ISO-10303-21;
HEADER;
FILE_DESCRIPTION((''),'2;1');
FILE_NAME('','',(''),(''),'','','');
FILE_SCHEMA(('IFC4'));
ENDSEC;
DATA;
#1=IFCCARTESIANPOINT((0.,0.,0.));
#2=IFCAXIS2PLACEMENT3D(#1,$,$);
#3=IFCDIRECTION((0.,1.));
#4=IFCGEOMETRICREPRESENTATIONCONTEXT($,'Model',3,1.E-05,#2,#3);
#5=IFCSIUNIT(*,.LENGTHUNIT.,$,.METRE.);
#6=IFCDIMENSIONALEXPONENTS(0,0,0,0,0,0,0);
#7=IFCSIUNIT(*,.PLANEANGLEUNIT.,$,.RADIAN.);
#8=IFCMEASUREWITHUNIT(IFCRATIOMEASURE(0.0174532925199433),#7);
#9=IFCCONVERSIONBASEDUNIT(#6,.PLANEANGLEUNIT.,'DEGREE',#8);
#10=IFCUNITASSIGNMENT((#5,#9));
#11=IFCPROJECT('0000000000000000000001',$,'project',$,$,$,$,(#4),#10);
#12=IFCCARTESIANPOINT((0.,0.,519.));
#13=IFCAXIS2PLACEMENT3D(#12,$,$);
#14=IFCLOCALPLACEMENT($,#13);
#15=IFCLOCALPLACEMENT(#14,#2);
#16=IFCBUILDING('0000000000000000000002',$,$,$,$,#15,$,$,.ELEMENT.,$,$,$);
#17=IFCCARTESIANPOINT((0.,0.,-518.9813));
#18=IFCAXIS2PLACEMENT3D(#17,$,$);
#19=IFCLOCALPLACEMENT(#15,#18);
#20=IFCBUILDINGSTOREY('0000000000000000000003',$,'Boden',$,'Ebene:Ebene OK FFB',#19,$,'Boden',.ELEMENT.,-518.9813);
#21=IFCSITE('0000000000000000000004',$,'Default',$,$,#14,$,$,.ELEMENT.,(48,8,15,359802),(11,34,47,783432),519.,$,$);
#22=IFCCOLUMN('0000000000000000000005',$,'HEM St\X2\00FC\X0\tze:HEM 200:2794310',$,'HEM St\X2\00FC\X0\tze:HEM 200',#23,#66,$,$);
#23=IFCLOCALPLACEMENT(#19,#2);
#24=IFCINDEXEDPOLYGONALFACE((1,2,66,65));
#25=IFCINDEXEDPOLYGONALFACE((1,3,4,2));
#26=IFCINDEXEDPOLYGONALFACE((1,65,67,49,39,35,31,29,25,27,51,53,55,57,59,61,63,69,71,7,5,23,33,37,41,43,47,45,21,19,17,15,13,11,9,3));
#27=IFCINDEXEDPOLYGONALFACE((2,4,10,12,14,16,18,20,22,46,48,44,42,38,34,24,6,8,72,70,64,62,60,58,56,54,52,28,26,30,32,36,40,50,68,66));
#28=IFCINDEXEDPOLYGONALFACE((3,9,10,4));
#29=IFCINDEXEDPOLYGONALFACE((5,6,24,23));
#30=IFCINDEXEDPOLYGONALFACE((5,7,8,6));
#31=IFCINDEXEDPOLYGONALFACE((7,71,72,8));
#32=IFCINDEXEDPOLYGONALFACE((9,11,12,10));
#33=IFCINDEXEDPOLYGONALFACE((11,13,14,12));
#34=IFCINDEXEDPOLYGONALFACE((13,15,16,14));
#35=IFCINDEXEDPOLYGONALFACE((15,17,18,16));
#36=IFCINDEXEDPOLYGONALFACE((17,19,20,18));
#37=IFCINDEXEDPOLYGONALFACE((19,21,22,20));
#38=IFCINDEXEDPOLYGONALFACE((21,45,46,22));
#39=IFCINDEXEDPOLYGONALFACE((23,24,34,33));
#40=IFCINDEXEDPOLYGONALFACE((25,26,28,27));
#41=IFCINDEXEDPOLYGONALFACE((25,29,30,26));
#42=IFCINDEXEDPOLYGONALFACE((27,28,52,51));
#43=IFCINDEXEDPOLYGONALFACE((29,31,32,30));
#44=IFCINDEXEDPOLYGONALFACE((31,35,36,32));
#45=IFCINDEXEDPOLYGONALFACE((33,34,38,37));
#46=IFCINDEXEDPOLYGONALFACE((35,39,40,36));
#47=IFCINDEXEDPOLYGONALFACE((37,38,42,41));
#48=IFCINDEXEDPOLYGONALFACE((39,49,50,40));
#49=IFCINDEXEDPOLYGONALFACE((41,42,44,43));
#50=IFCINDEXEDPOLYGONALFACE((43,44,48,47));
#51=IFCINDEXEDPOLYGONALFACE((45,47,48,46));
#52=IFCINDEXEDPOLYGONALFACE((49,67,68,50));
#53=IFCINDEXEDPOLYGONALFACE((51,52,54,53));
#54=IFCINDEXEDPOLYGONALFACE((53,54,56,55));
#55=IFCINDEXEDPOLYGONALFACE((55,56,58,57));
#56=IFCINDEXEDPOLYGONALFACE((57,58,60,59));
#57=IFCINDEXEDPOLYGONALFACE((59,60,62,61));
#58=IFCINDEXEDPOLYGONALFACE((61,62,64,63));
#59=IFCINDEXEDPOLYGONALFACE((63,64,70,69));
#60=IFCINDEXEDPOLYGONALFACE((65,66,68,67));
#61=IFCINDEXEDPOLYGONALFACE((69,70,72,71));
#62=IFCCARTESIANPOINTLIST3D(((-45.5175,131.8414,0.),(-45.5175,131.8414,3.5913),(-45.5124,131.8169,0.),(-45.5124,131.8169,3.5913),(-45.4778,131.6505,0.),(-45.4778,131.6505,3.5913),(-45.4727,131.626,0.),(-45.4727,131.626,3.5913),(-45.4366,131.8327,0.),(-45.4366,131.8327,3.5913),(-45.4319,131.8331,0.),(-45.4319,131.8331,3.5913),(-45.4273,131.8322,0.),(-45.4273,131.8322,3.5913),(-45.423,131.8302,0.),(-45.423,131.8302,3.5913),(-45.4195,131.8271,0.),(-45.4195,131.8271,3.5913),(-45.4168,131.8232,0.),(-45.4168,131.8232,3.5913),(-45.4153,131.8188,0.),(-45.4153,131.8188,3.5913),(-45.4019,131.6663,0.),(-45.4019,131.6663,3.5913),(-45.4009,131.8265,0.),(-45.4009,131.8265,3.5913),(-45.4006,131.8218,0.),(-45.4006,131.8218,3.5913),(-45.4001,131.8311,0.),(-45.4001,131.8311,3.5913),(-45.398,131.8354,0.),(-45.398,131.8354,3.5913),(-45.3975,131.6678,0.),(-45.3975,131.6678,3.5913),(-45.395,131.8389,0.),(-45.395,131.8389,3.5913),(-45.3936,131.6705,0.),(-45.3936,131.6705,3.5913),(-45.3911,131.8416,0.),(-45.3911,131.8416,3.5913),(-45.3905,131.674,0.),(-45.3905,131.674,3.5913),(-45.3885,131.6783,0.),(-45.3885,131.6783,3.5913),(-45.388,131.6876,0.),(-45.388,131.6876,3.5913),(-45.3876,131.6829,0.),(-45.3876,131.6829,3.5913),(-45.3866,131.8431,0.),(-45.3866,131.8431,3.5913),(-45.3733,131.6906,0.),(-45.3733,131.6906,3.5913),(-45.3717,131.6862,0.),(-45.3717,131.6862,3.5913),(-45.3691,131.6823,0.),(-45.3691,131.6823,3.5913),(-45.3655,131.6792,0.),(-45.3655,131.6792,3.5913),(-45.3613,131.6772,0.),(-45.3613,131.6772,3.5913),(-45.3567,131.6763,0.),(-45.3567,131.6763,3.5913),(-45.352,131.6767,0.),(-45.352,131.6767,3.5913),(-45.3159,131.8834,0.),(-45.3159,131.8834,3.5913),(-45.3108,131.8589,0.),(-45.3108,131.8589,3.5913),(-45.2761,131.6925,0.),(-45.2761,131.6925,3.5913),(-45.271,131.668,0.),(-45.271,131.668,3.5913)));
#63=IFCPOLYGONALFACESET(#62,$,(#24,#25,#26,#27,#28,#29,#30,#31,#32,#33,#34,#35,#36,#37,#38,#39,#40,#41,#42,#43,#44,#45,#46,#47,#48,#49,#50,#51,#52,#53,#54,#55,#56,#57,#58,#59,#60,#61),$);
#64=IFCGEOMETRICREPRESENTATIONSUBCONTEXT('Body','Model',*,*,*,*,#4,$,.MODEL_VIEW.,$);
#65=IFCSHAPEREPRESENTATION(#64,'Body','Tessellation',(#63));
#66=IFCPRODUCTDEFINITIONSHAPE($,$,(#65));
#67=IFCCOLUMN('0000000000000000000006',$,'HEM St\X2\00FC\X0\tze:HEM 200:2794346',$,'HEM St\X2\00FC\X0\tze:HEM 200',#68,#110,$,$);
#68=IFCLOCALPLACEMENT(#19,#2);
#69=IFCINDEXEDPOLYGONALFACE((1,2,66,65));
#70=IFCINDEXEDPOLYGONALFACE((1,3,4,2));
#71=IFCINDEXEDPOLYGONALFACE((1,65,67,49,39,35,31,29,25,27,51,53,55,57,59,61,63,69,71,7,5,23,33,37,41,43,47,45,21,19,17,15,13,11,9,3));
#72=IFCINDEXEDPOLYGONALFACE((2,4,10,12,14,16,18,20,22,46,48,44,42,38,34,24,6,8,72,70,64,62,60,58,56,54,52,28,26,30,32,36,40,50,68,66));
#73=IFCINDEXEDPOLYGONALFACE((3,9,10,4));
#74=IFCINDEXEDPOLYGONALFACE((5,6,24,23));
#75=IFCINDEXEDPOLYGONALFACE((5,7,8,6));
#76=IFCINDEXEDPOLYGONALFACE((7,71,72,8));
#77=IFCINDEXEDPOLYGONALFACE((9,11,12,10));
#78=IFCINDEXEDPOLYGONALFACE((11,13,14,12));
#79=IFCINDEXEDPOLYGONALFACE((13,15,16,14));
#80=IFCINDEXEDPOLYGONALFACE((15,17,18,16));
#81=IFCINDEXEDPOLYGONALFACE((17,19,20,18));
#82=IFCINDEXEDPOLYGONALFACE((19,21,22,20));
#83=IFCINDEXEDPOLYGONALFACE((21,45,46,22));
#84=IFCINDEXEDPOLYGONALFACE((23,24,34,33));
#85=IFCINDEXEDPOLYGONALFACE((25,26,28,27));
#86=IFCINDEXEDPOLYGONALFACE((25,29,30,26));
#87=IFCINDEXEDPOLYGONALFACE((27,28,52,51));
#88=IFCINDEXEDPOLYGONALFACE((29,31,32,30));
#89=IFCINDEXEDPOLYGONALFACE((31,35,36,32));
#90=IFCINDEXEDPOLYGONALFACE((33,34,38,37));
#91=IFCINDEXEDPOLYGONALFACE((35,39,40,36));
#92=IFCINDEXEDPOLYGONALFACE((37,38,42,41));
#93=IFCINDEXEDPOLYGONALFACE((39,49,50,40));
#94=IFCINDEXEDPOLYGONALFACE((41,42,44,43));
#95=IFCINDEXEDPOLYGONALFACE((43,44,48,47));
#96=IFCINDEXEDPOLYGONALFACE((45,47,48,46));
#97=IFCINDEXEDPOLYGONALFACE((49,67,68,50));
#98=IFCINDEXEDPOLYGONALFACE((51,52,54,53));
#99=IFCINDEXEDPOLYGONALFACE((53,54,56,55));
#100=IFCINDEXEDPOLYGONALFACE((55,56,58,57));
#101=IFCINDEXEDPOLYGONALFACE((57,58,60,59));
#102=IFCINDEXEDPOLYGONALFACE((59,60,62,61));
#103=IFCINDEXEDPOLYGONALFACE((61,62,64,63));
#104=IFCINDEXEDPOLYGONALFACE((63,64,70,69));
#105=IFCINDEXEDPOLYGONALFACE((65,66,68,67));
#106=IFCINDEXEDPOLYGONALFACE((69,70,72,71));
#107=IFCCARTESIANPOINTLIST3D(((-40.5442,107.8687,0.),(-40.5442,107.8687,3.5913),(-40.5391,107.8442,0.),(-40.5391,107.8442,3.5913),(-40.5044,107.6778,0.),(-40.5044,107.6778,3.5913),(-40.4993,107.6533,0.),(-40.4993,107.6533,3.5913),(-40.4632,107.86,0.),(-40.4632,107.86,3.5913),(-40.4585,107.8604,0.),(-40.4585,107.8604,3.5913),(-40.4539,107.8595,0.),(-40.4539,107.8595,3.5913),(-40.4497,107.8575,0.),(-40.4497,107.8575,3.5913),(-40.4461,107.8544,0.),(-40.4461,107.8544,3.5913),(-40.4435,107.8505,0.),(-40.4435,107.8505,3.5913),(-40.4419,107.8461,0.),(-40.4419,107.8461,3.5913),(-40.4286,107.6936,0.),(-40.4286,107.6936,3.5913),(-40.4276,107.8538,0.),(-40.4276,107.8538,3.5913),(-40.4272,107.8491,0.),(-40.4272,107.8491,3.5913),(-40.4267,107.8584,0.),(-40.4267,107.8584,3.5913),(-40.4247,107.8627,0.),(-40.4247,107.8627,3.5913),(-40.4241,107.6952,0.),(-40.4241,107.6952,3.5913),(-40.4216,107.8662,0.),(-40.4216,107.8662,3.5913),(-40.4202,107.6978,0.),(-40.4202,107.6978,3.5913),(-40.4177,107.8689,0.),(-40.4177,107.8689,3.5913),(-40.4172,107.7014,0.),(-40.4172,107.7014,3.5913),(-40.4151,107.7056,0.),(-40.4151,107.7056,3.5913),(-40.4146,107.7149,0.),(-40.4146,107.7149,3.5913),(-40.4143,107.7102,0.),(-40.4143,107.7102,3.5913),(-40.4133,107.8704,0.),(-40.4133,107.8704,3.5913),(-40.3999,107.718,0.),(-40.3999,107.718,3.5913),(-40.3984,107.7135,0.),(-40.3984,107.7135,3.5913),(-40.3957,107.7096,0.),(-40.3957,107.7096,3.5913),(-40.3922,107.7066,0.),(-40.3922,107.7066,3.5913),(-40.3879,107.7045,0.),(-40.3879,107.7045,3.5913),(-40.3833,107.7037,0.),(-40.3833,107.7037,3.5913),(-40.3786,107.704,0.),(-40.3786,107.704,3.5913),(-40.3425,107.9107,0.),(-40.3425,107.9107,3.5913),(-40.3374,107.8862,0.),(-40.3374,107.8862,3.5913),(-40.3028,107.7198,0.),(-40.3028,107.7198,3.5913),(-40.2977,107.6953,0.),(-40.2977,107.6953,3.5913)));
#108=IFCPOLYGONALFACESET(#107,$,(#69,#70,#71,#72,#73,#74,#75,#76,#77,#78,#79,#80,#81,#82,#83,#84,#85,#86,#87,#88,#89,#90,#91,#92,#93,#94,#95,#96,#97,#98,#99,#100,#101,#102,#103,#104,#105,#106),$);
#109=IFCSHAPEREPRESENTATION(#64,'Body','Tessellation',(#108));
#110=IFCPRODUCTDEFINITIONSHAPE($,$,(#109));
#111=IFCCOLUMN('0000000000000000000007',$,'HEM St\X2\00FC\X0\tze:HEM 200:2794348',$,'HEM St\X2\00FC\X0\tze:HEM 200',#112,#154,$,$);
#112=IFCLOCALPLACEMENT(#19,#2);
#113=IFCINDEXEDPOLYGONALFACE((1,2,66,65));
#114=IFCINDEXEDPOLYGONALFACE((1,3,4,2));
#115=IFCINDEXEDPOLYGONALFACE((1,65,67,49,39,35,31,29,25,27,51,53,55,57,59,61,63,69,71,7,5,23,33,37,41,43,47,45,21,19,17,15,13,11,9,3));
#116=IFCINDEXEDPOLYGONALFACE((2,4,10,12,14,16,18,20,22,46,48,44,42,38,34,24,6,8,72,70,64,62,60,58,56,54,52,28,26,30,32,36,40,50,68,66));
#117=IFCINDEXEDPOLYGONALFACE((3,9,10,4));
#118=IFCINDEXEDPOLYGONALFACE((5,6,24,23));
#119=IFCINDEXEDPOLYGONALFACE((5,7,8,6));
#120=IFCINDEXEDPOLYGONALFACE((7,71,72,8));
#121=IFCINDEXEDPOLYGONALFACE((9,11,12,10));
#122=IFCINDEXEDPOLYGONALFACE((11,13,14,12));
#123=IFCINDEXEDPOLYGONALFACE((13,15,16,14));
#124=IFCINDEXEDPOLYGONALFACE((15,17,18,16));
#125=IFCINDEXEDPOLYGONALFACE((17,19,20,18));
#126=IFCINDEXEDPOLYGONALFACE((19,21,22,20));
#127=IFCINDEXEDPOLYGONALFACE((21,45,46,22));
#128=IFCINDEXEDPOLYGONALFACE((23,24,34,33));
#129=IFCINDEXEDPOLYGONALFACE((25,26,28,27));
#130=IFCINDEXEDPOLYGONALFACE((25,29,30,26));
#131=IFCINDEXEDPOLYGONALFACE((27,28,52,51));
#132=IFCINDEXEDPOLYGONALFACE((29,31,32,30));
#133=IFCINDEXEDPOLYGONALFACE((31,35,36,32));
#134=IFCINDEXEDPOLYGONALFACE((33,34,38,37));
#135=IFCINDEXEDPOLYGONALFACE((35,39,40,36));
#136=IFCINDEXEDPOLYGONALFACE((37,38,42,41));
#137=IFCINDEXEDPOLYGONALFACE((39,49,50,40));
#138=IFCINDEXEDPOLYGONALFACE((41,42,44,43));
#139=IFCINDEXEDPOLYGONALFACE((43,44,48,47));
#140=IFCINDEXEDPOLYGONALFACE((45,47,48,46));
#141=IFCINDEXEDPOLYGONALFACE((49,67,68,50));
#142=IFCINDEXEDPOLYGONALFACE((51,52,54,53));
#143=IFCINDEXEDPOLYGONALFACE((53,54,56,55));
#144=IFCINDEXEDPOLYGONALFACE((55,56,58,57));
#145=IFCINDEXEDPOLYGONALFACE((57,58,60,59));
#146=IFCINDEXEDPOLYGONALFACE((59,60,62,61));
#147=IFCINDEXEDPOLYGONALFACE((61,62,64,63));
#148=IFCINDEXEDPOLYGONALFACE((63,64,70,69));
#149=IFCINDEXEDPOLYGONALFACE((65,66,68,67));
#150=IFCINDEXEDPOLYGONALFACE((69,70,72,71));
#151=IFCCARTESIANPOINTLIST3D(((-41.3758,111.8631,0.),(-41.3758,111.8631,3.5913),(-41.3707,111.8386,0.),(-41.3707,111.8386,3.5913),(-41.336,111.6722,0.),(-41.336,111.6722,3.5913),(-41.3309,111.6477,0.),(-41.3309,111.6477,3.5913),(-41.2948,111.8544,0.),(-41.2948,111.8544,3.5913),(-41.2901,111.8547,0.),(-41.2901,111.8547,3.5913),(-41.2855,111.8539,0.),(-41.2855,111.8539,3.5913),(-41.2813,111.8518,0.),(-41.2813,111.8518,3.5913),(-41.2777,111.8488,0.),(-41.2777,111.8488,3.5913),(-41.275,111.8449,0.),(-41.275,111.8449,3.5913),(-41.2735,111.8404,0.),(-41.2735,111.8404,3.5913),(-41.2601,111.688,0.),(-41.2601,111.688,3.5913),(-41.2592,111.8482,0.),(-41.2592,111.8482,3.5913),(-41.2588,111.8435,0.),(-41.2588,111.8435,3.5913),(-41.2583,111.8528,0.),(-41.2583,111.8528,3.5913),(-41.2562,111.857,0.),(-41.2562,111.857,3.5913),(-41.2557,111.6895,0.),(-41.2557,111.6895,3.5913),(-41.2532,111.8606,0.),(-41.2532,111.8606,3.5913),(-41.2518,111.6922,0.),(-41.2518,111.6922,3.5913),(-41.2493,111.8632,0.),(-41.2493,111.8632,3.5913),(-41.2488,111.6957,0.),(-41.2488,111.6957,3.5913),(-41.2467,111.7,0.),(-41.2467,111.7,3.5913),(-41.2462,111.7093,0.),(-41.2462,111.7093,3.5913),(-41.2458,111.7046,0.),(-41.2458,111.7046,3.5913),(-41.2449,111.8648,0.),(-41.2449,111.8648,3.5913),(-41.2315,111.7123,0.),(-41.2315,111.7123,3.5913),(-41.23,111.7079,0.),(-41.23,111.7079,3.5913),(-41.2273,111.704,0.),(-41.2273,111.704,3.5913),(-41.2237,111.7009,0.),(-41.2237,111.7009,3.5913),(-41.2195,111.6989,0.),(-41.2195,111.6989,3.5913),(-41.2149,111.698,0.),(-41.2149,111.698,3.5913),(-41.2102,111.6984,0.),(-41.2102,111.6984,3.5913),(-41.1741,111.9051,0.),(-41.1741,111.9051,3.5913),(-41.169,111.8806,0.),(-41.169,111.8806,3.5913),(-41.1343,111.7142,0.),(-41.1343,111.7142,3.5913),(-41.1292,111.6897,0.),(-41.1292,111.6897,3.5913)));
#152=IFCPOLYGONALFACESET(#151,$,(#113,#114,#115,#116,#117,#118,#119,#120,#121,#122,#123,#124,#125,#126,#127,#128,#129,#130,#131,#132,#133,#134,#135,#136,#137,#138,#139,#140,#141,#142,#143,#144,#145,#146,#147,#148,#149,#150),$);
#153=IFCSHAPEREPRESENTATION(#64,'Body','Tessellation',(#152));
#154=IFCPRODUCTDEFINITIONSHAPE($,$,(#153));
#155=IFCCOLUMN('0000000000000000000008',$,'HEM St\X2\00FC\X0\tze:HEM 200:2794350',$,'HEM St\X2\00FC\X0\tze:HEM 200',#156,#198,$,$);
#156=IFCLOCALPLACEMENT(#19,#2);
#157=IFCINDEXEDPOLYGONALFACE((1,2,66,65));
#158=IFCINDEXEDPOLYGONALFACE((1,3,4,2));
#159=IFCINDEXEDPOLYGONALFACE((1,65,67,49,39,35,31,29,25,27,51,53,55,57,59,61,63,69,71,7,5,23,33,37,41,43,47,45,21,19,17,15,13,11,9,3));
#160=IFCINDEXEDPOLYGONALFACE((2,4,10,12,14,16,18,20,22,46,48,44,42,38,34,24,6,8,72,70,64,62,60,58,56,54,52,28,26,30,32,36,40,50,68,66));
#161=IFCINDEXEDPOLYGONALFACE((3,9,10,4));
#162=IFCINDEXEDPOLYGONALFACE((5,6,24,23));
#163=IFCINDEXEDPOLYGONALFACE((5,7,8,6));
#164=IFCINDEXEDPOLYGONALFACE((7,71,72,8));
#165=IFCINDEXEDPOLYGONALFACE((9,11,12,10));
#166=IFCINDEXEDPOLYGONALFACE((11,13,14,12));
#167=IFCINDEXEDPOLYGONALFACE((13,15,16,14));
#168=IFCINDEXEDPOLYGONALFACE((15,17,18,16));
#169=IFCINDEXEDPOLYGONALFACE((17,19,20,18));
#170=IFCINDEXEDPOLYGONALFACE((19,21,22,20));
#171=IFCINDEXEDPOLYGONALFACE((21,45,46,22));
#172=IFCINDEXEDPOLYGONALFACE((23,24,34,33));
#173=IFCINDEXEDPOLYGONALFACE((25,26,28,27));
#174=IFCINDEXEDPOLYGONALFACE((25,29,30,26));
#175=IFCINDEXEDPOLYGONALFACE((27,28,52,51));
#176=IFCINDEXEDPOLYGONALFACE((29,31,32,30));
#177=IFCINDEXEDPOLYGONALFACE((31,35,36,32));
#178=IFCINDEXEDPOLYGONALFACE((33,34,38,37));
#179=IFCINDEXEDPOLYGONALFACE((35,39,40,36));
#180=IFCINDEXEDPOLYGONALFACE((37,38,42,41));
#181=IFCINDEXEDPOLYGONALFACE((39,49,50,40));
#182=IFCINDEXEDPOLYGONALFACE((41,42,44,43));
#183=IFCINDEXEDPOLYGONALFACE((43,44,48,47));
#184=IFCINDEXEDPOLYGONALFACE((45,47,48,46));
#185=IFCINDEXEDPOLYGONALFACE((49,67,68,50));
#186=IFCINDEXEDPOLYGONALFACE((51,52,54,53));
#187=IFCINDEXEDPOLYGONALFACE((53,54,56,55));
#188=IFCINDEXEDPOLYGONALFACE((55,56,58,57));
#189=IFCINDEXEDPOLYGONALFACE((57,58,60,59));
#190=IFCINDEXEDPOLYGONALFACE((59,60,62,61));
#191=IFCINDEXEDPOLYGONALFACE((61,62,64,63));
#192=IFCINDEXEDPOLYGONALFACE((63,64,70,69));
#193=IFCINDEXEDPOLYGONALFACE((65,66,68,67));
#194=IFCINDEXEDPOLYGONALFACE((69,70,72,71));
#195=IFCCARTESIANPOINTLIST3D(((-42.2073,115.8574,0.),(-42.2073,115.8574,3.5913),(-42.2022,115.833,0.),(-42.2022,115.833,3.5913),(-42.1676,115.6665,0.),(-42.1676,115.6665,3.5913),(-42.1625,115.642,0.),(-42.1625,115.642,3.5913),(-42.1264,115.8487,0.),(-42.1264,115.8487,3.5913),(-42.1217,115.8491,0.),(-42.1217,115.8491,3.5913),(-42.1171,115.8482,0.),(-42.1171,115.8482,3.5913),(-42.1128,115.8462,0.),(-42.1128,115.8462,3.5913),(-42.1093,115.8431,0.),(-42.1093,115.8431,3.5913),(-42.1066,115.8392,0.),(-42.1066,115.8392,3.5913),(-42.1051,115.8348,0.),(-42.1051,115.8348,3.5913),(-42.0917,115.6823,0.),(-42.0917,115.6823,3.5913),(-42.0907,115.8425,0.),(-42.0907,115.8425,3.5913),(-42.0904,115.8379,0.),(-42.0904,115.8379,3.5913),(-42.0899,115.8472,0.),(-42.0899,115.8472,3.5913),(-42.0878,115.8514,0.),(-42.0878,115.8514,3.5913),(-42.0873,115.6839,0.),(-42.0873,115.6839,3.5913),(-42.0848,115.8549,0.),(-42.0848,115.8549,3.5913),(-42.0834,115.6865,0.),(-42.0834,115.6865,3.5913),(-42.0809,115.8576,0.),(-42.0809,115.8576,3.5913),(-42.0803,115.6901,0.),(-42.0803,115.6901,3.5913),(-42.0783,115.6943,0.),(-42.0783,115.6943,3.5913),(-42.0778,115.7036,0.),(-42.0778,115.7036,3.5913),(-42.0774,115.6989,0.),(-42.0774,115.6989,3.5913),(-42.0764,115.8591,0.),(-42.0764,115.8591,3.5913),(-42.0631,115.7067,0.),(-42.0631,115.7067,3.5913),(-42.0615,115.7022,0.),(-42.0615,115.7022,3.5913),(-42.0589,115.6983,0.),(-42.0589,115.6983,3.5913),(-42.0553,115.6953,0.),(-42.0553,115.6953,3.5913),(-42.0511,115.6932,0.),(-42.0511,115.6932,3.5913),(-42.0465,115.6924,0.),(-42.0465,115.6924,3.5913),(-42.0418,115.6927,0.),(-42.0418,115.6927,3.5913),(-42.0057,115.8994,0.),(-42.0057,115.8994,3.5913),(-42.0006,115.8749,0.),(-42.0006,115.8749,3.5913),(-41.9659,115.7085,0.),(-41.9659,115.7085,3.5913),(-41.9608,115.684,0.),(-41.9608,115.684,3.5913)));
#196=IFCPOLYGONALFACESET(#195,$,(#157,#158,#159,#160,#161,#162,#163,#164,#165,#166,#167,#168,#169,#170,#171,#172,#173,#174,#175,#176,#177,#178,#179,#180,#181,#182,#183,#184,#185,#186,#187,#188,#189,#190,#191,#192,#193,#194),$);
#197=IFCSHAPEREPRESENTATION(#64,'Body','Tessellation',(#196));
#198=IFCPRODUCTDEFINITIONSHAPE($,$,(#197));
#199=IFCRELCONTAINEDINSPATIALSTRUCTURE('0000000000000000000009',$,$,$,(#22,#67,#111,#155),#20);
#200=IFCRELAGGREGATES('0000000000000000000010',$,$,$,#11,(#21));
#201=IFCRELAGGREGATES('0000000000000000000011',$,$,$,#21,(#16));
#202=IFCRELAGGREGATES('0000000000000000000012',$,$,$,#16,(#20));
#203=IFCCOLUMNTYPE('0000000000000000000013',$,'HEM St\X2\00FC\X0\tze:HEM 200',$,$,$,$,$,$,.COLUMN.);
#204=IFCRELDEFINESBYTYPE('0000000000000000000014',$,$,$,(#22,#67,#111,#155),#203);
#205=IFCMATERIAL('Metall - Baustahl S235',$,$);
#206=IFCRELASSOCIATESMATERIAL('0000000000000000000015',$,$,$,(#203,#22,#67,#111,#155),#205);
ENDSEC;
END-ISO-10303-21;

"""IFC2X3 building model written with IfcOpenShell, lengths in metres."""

from ifc_helpers import new_model, entity, si_unit, converted_unit, direction, frame, frame_2d, origin, place, context, subcontext, project, spatial, polyline, circle_curve, parameter, trimmed, segment, composite_curve, outline, extrude, source, transform, mapped, material, type_object, type_shapes, element, save


model = new_model("IFC2X3")

# Units and contexts
model_context = context("Model", 3, precision=1e-05, world=origin(), true_north=direction((0.0, 1.0)))
body_context = subcontext(model_context, "Body", "Model", "MODEL_VIEW")
ifc_project = project(units=[si_unit("LENGTHUNIT", "METRE"), converted_unit("PLANEANGLEUNIT", "DEGREE", entity("IfcRatioMeasure", 0.0174532925199433), si_unit("PLANEANGLEUNIT", "RADIAN"), dimensions=[0, 0, 0, 0, 0, 0, 0])], contexts=[model_context])

# Site, building, storey
site_placement = place(None, frame((0.0, 0.0, 519.0)))
site = spatial("IfcSite", under=ifc_project, at=site_placement, Name="Default", CompositionType="ELEMENT", RefLatitude=(48, 8, 15, 359802), RefLongitude=(11, 34, 47, 783432), RefElevation=519.0)
building_placement = place(site_placement, origin())
building = spatial("IfcBuilding", under=site, at=building_placement, CompositionType="ELEMENT")
storey_placement = place(building_placement, frame((0.0, 0.0, -518.9813)))
storey = spatial("IfcBuildingStorey", under=building, at=storey_placement, Name="Boden", ObjectType="Ebene:Ebene OK FFB", LongName="Boden", CompositionType="ELEMENT", Elevation=-518.9813)

# Columns
ifc_material = material(Name="Metall - Baustahl S235")
column_type = type_object("IfcColumnType", Name="HEM Stütze:HEM 200", PredefinedType="COLUMN", material=ifc_material)
shared_shape = source(origin(), body_context, "Body", "SweptSolid", [
    extrude(outline(composite_curve([segment(polyline([(0.085, -0.103), (0.11, -0.103)]), True, "CONTINUOUS"), segment(polyline([(0.11, -0.103), (0.11, 0.103)]), True, "CONTINUOUS"), segment(polyline([(0.11, 0.103), (0.085, 0.103)]), True, "CONTINUOUS"), segment(polyline([(0.085, 0.103), (0.085, 0.0255)]), True, "CONTINUOUS"), segment(trimmed(circle_curve(frame_2d((0.067, 0.0255), x_axis=(1.0, 0.0)), 0.018), [parameter(270.0)], [parameter(0.0)], True, "PARAMETER"), False, "CONTINUOUS"), segment(polyline([(0.067, 0.0075), (-0.067, 0.0075)]), True, "CONTINUOUS"), segment(trimmed(circle_curve(frame_2d((-0.067, 0.0255), x_axis=(0.0, -1.0)), 0.018), [parameter(270.0)], [parameter(0.0)], True, "PARAMETER"), False, "CONTINUOUS"), segment(polyline([(-0.085, 0.0255), (-0.085, 0.103)]), True, "CONTINUOUS"), segment(polyline([(-0.085, 0.103), (-0.11, 0.103)]), True, "CONTINUOUS"), segment(polyline([(-0.11, 0.103), (-0.11, -0.103)]), True, "CONTINUOUS"), segment(polyline([(-0.11, -0.103), (-0.085, -0.103)]), True, "CONTINUOUS"), segment(polyline([(-0.085, -0.103), (-0.085, -0.0255)]), True, "CONTINUOUS"), segment(trimmed(circle_curve(frame_2d((-0.067, -0.0255), x_axis=(-1.0, 0.0)), 0.018), [parameter(270.0)], [parameter(0.0)], True, "PARAMETER"), False, "CONTINUOUS"), segment(polyline([(-0.067, -0.0075), (0.067, -0.0075)]), True, "CONTINUOUS"), segment(trimmed(circle_curve(frame_2d((0.067, -0.0255), x_axis=(0.0, 1.0)), 0.018), [parameter(270.0)], [parameter(0.0)], True, "PARAMETER"), False, "CONTINUOUS"), segment(polyline([(0.085, -0.0255), (0.085, -0.103)]), True, "CONTINUOUS")], self_intersect=False)), frame((0.0, 0.0, -518.9813), z_axis=(0.0, 0.0, 1.0), x_axis=(0.0, -1.0, 0.0)), (0.0, 0.0, 1.0), 3.5913),
])
type_shapes(column_type, [shared_shape])
for number, where, z_axis, x_axis, name in (
    (1, (-45.3943, 131.7547, 518.9813), (0.0, 0.0, 1.0), (0.979008, 0.20382, 0.0), "HEM Stütze:HEM 200:2794310"),
    (2, (-40.4209, 107.782, 518.9813), (0.0, 0.0, 1.0), (0.979008, 0.20382, 0.0), "HEM Stütze:HEM 200:2794346"),
    (3, (-41.2525, 111.7764, 518.9813), (0.0, 0.0, 1.0), (0.979008, 0.20382, 0.0), "HEM Stütze:HEM 200:2794348"),
    (4, (-42.0841, 115.7707, 518.9813), (0.0, 0.0, 1.0), (0.979008, 0.20382, 0.0), "HEM Stütze:HEM 200:2794350"),
):
    element("IfcColumn", number, at=place(storey_placement, frame(where, z_axis=z_axis, x_axis=x_axis)), inside=storey, type_object=column_type, material=ifc_material, Name=name, ObjectType="HEM Stütze:HEM 200", context=body_context, shape_type="MappedRepresentation", body=[
        mapped(shared_shape, transform((0.0, 0.0, 0.0), scale=1.0)),
    ])

save(model, "model.ifc")
